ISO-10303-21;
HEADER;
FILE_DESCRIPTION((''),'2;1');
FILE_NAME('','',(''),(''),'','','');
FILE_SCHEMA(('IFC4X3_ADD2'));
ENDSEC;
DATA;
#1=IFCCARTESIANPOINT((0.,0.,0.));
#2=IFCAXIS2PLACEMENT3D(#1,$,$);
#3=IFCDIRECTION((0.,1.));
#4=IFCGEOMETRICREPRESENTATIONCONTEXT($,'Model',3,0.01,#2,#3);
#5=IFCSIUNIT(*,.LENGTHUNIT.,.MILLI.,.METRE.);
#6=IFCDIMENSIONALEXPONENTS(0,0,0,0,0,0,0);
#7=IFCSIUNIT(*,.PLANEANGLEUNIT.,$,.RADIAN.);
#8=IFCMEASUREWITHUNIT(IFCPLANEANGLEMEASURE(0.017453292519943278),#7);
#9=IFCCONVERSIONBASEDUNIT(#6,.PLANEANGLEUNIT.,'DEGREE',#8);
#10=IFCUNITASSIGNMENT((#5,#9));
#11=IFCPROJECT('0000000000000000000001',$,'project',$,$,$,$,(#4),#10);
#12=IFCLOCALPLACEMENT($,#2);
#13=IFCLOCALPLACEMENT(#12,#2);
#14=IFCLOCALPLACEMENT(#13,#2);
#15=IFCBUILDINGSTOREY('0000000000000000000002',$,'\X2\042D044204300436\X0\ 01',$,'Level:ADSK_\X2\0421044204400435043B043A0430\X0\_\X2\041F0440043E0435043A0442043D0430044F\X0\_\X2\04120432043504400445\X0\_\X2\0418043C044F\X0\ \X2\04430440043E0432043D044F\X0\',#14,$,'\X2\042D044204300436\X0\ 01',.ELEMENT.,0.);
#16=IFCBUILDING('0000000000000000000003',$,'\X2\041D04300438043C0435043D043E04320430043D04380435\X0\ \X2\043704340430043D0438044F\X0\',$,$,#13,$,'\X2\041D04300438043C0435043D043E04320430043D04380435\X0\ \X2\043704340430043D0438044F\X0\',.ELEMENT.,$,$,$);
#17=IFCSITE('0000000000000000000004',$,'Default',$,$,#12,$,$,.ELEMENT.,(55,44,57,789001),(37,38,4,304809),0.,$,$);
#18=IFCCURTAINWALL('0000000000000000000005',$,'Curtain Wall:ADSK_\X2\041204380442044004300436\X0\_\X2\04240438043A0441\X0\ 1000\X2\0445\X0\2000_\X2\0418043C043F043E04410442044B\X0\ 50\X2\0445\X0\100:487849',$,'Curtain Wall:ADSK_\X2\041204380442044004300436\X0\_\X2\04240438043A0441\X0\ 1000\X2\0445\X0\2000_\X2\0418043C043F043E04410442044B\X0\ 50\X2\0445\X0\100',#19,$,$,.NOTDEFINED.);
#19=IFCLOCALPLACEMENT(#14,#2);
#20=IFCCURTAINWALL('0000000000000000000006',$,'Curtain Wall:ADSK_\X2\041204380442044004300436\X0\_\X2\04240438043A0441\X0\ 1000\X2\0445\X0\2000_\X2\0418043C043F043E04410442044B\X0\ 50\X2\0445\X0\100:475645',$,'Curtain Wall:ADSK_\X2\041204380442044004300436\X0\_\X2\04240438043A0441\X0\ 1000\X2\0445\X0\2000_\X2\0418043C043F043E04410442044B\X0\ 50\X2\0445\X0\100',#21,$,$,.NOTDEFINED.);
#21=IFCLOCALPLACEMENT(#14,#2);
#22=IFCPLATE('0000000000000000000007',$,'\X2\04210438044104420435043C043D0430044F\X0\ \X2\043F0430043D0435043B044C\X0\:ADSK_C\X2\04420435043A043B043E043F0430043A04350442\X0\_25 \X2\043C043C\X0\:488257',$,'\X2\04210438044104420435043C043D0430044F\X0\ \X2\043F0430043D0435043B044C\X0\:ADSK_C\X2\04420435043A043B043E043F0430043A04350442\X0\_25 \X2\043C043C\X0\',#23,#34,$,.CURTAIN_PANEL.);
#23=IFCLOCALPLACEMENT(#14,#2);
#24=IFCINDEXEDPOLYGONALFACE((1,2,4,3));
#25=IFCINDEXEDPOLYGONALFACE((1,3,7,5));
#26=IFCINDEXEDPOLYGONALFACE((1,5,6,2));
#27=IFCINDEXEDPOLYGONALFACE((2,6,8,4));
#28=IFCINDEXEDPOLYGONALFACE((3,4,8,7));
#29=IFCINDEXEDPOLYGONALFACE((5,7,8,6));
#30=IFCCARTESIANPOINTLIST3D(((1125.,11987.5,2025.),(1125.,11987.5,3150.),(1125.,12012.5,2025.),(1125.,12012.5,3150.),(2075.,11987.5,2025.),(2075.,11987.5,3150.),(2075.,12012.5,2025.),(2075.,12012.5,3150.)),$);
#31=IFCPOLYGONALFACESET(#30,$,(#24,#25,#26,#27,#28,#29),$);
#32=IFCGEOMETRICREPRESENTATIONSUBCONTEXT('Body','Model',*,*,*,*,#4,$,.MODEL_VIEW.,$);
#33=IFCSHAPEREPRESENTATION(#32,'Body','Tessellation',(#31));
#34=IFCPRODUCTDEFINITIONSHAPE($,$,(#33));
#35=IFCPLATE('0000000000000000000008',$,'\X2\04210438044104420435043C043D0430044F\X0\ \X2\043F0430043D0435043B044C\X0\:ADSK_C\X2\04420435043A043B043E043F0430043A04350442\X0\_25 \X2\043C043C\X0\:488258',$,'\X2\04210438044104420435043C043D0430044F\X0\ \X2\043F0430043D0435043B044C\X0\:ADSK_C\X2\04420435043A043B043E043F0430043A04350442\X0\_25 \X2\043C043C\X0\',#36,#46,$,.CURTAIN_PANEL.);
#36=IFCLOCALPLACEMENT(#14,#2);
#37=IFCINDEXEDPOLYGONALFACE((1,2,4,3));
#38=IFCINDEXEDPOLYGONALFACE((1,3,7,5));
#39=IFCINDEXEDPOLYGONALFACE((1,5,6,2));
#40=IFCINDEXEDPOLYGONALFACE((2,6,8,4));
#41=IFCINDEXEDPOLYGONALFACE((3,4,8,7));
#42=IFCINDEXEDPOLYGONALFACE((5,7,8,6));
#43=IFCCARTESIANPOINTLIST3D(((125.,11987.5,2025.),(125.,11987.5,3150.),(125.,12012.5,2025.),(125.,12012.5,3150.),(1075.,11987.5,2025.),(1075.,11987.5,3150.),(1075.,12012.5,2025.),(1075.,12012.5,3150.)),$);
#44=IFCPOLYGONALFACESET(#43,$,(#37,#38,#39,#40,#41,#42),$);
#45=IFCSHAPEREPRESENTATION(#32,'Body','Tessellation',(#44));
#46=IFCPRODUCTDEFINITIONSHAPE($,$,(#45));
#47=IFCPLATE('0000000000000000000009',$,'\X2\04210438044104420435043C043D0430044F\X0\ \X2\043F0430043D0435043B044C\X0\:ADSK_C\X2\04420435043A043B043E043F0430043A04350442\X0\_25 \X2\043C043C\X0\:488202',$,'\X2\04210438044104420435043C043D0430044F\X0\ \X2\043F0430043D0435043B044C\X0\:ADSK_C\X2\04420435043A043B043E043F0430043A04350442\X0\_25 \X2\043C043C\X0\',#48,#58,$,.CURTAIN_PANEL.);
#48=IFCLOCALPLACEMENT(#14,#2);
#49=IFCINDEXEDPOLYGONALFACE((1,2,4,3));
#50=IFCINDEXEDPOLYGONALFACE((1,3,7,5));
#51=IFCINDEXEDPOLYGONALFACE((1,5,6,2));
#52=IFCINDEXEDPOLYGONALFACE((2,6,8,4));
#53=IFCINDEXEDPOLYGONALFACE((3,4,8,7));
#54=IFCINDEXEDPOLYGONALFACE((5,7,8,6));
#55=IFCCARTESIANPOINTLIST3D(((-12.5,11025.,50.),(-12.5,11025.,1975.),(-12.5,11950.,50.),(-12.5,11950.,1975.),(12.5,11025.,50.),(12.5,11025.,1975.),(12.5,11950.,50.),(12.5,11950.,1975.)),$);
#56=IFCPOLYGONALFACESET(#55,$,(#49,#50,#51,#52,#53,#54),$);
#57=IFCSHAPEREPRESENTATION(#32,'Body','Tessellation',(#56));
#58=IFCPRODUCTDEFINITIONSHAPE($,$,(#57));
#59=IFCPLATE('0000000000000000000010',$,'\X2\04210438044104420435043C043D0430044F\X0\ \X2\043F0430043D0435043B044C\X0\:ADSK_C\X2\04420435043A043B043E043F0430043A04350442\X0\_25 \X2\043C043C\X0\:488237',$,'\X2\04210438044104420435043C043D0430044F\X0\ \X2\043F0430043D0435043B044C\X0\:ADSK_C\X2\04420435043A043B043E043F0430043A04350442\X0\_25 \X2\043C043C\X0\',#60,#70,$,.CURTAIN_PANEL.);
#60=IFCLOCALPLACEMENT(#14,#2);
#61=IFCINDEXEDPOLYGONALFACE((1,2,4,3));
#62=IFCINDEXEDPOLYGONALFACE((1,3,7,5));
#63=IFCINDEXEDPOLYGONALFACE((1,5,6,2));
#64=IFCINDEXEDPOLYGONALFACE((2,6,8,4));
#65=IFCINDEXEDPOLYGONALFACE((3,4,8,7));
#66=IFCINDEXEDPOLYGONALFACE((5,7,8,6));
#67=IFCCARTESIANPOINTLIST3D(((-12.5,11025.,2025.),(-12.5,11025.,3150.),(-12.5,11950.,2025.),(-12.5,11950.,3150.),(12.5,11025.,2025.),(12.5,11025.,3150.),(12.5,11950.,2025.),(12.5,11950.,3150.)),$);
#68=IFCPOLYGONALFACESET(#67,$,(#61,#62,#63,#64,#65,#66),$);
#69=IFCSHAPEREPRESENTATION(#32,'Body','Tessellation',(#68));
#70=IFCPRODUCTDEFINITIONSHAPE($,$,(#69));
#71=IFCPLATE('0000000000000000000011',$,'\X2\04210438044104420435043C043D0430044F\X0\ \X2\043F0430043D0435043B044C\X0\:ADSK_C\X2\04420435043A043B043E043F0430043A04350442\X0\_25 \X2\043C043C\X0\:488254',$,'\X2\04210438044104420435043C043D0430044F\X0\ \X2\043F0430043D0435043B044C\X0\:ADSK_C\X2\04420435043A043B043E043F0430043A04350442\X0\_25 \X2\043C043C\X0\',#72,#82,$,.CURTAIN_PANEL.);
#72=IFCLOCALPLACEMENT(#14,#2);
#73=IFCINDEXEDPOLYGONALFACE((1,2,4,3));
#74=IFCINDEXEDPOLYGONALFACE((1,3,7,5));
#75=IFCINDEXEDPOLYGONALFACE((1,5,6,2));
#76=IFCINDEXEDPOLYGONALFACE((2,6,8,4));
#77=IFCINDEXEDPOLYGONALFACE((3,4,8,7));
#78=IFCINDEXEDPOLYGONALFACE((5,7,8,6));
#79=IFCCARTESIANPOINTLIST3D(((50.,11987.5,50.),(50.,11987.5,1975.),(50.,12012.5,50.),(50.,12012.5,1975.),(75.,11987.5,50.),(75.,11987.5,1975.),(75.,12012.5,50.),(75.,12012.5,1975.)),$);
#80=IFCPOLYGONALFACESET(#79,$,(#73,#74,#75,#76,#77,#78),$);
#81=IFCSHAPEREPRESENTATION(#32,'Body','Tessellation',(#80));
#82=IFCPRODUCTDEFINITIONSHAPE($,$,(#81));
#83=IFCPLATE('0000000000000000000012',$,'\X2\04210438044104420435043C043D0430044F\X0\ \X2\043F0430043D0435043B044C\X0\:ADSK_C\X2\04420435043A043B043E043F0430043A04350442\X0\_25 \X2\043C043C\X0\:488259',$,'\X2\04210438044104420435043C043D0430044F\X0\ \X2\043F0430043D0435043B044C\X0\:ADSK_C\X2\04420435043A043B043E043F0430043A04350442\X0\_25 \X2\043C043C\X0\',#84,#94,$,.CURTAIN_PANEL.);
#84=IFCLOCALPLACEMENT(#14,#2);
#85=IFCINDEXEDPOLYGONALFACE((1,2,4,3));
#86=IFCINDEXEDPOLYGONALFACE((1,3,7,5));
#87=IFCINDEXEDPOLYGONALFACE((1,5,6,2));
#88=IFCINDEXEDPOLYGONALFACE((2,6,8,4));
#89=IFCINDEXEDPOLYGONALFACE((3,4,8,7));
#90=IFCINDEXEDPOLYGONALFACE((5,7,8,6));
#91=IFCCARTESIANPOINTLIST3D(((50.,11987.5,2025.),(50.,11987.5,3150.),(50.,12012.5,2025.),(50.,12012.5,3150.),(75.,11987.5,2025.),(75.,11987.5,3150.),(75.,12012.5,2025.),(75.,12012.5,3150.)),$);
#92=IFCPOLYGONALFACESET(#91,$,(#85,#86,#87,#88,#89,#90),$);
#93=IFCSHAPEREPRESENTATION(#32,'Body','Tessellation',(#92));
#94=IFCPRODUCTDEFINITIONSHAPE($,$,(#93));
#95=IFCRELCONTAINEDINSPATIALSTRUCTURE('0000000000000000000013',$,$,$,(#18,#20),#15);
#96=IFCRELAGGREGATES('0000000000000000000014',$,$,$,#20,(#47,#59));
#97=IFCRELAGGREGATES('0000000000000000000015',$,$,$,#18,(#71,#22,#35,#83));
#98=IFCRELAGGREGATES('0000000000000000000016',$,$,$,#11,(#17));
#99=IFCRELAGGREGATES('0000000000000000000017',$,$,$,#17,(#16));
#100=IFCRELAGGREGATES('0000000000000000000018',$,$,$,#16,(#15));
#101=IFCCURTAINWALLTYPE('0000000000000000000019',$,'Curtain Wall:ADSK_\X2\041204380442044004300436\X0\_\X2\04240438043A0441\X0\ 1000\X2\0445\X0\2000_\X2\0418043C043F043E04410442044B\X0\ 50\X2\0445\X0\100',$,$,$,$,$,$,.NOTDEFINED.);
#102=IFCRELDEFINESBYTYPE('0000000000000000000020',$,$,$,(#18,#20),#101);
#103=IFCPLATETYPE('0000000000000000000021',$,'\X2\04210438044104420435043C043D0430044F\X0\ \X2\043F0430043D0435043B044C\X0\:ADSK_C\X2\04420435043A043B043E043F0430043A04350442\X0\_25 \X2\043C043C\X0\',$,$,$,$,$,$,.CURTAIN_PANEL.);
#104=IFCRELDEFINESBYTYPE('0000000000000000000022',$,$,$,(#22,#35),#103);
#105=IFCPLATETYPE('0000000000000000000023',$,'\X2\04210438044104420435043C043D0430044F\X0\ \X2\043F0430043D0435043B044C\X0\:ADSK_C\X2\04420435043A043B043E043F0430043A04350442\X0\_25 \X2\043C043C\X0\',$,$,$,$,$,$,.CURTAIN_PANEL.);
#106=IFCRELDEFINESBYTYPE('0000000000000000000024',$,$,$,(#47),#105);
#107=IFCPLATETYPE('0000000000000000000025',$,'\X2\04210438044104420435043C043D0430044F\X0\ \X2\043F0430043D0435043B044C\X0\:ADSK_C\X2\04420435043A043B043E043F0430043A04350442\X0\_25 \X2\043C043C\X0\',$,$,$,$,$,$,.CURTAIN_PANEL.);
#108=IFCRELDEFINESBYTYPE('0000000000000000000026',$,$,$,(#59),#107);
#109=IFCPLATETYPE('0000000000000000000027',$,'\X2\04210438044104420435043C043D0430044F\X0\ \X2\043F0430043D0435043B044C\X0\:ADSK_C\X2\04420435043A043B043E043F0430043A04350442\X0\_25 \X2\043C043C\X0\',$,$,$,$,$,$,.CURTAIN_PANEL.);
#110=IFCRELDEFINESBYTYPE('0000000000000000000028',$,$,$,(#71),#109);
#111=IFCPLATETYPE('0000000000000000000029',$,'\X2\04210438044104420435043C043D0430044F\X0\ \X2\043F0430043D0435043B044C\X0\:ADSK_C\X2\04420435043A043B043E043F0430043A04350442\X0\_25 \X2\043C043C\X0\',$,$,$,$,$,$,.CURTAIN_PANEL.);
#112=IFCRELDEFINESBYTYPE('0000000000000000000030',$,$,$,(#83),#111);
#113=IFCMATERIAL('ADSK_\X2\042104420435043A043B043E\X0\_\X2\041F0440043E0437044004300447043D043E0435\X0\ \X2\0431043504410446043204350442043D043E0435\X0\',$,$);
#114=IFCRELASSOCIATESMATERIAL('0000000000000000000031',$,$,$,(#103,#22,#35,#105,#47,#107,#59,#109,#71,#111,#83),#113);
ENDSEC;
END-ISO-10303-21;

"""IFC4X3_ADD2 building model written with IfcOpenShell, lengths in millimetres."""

from ifc_helpers import new_model, entity, si_unit, converted_unit, direction, frame, origin, origin_2d_with_axis, place, context, subcontext, project, spatial, rectangle, extrude, source, transform, mapped, material, type_object, type_shapes, element, aggregate, save


model = new_model("IFC4X3_ADD2")

# Units and contexts
model_context = context("Model", 3, precision=0.01, world=origin(), true_north=direction((0.0, 1.0)))
body_context = subcontext(model_context, "Body", "Model", "MODEL_VIEW")
ifc_project = project(units=[si_unit("LENGTHUNIT", "METRE", prefix="MILLI"), converted_unit("PLANEANGLEUNIT", "DEGREE", entity("IfcPlaneAngleMeasure", 0.017453292519943278), si_unit("PLANEANGLEUNIT", "RADIAN"), dimensions=[0, 0, 0, 0, 0, 0, 0])], contexts=[model_context])

# Site, building, storey
site_placement = place(None, origin())
site = spatial("IfcSite", under=ifc_project, at=site_placement, Name="Default", CompositionType="ELEMENT", RefLatitude=(55, 44, 57, 789001), RefLongitude=(37, 38, 4, 304809), RefElevation=0.0)
building_placement = place(site_placement, origin())
building = spatial("IfcBuilding", under=site, at=building_placement, Name="Наименование здания", LongName="Наименование здания", CompositionType="ELEMENT")
storey_placement = place(building_placement, origin())
storey = spatial("IfcBuildingStorey", under=building, at=storey_placement, Name="Этаж 01", ObjectType="Level:ADSK_Стрелка_Проектная_Вверх_Имя уровня", LongName="Этаж 01", CompositionType="ELEMENT", Elevation=0.0)

# Curtain walls
curtain_wall_type = type_object("IfcCurtainWallType", Name="Curtain Wall:ADSK_Витраж_Фикс 1000х2000_Импосты 50х100", PredefinedType="NOTDEFINED")
curtain_wall_1_placement = place(storey_placement, origin())
curtain_wall_1 = element("IfcCurtainWall", 1, at=curtain_wall_1_placement, inside=storey, type_object=curtain_wall_type, Name="Curtain Wall:ADSK_Витраж_Фикс 1000х2000_Импосты 50х100:487849", ObjectType="Curtain Wall:ADSK_Витраж_Фикс 1000х2000_Импосты 50х100", PredefinedType="NOTDEFINED")
ifc_material = material(Name="ADSK_Стекло_Прозрачное бесцветное")
curtain_wall_2_placement = place(storey_placement, origin())
curtain_wall_2 = element("IfcCurtainWall", 2, at=curtain_wall_2_placement, inside=storey, type_object=curtain_wall_type, Name="Curtain Wall:ADSK_Витраж_Фикс 1000х2000_Импосты 50х100:475645", ObjectType="Curtain Wall:ADSK_Витраж_Фикс 1000х2000_Импосты 50х100", PredefinedType="NOTDEFINED")

# Plates
plate_type_1 = type_object("IfcPlateType", Name="Системная панель:ADSK_Cтеклопакет_25 мм", PredefinedType="CURTAIN_PANEL", material=ifc_material)
shared_shape_1 = source(origin(), body_context, "Body", "SweptSolid", [
    extrude(rectangle(XDim=25.0, YDim=950.0, at=origin_2d_with_axis()), frame((0.0, 0.0, 0.0), z_axis=(0.0, 0.0, 1.0), x_axis=(0.0, 1.0, 0.0)), (0.0, 0.0, 1.0), 1125.0),
])
type_shapes(plate_type_1, [shared_shape_1])
plate_1_placement = place(curtain_wall_1_placement, frame((1600.0, 12000.0, 2025.0), z_axis=(0.0, 0.0, 1.0), x_axis=(-1.0, 0.0, 0.0)))
plate_1 = element("IfcPlate", 3, at=plate_1_placement, type_object=plate_type_1, material=ifc_material, Name="Системная панель:ADSK_Cтеклопакет_25 мм:488257", ObjectType="Системная панель:ADSK_Cтеклопакет_25 мм", PredefinedType="CURTAIN_PANEL", context=body_context, shape_type="MappedRepresentation", body=[
    mapped(shared_shape_1, transform((0.0, 0.0, 0.0), scale=1.0)),
])
plate_2_placement = place(curtain_wall_1_placement, frame((600.0, 12000.0, 2025.0), z_axis=(0.0, 0.0, 1.0), x_axis=(-1.0, 0.0, 0.0)))
plate_2 = element("IfcPlate", 4, at=plate_2_placement, type_object=plate_type_1, material=ifc_material, Name="Системная панель:ADSK_Cтеклопакет_25 мм:488258", ObjectType="Системная панель:ADSK_Cтеклопакет_25 мм", PredefinedType="CURTAIN_PANEL", context=body_context, shape_type="MappedRepresentation", body=[
    mapped(shared_shape_1, transform((0.0, 0.0, 0.0), scale=1.0)),
])
plate_type_2 = type_object("IfcPlateType", Name="Системная панель:ADSK_Cтеклопакет_25 мм", PredefinedType="CURTAIN_PANEL", material=ifc_material)
shared_shape_2 = source(origin(), body_context, "Body", "SweptSolid", [
    extrude(rectangle(XDim=25.0, YDim=925.0, at=origin_2d_with_axis()), frame((0.0, 0.0, 0.0), z_axis=(0.0, 0.0, 1.0), x_axis=(0.0, 1.0, 0.0)), (0.0, 0.0, 1.0), 1925.0),
])
type_shapes(plate_type_2, [shared_shape_2])
plate_3_placement = place(curtain_wall_2_placement, frame((0.0, 11487.5, 50.0), z_axis=(0.0, 0.0, 1.0), x_axis=(0.0, -1.0, 0.0)))
plate_3 = element("IfcPlate", 5, at=plate_3_placement, type_object=plate_type_2, material=ifc_material, Name="Системная панель:ADSK_Cтеклопакет_25 мм:488202", ObjectType="Системная панель:ADSK_Cтеклопакет_25 мм", PredefinedType="CURTAIN_PANEL", context=body_context, shape_type="MappedRepresentation", body=[
    mapped(shared_shape_2, transform((0.0, 0.0, 0.0), scale=1.0)),
])
plate_type_3 = type_object("IfcPlateType", Name="Системная панель:ADSK_Cтеклопакет_25 мм", PredefinedType="CURTAIN_PANEL", material=ifc_material)
shared_shape_3 = source(origin(), body_context, "Body", "SweptSolid", [
    extrude(rectangle(XDim=25.0, YDim=925.0, at=origin_2d_with_axis()), frame((0.0, 0.0, 0.0), z_axis=(0.0, 0.0, 1.0), x_axis=(0.0, 1.0, 0.0)), (0.0, 0.0, 1.0), 1125.0),
])
type_shapes(plate_type_3, [shared_shape_3])
plate_4_placement = place(curtain_wall_2_placement, frame((0.0, 11487.5, 2025.0), z_axis=(0.0, 0.0, 1.0), x_axis=(0.0, -1.0, 0.0)))
plate_4 = element("IfcPlate", 6, at=plate_4_placement, type_object=plate_type_3, material=ifc_material, Name="Системная панель:ADSK_Cтеклопакет_25 мм:488237", ObjectType="Системная панель:ADSK_Cтеклопакет_25 мм", PredefinedType="CURTAIN_PANEL", context=body_context, shape_type="MappedRepresentation", body=[
    mapped(shared_shape_3, transform((0.0, 0.0, 0.0), scale=1.0)),
])
aggregate(curtain_wall_2, [plate_3, plate_4])
plate_type_4 = type_object("IfcPlateType", Name="Системная панель:ADSK_Cтеклопакет_25 мм", PredefinedType="CURTAIN_PANEL", material=ifc_material)
shared_shape_4 = source(origin(), body_context, "Body", "SweptSolid", [
    extrude(rectangle(XDim=25.0, YDim=25.0, at=origin_2d_with_axis()), frame((0.0, 0.0, 0.0), z_axis=(0.0, 0.0, 1.0), x_axis=(0.0, 1.0, 0.0)), (0.0, 0.0, 1.0), 1925.0),
])
type_shapes(plate_type_4, [shared_shape_4])
plate_5_placement = place(curtain_wall_1_placement, frame((62.5, 12000.0, 50.0), z_axis=(0.0, 0.0, 1.0), x_axis=(-1.0, 0.0, 0.0)))
plate_5 = element("IfcPlate", 7, at=plate_5_placement, type_object=plate_type_4, material=ifc_material, Name="Системная панель:ADSK_Cтеклопакет_25 мм:488254", ObjectType="Системная панель:ADSK_Cтеклопакет_25 мм", PredefinedType="CURTAIN_PANEL", context=body_context, shape_type="MappedRepresentation", body=[
    mapped(shared_shape_4, transform((0.0, 0.0, 0.0), scale=1.0)),
])
plate_type_5 = type_object("IfcPlateType", Name="Системная панель:ADSK_Cтеклопакет_25 мм", PredefinedType="CURTAIN_PANEL", material=ifc_material)
shared_shape_5 = source(origin(), body_context, "Body", "SweptSolid", [
    extrude(rectangle(XDim=25.0, YDim=25.0, at=origin_2d_with_axis()), frame((0.0, 0.0, 0.0), z_axis=(0.0, 0.0, 1.0), x_axis=(0.0, 1.0, 0.0)), (0.0, 0.0, 1.0), 1125.0),
])
type_shapes(plate_type_5, [shared_shape_5])
plate_6_placement = place(curtain_wall_1_placement, frame((62.5, 12000.0, 2025.0), z_axis=(0.0, 0.0, 1.0), x_axis=(-1.0, 0.0, 0.0)))
plate_6 = element("IfcPlate", 8, at=plate_6_placement, type_object=plate_type_5, material=ifc_material, Name="Системная панель:ADSK_Cтеклопакет_25 мм:488259", ObjectType="Системная панель:ADSK_Cтеклопакет_25 мм", PredefinedType="CURTAIN_PANEL", context=body_context, shape_type="MappedRepresentation", body=[
    mapped(shared_shape_5, transform((0.0, 0.0, 0.0), scale=1.0)),
])
aggregate(curtain_wall_1, [plate_5, plate_1, plate_2, plate_6])

save(model, "model.ifc")
